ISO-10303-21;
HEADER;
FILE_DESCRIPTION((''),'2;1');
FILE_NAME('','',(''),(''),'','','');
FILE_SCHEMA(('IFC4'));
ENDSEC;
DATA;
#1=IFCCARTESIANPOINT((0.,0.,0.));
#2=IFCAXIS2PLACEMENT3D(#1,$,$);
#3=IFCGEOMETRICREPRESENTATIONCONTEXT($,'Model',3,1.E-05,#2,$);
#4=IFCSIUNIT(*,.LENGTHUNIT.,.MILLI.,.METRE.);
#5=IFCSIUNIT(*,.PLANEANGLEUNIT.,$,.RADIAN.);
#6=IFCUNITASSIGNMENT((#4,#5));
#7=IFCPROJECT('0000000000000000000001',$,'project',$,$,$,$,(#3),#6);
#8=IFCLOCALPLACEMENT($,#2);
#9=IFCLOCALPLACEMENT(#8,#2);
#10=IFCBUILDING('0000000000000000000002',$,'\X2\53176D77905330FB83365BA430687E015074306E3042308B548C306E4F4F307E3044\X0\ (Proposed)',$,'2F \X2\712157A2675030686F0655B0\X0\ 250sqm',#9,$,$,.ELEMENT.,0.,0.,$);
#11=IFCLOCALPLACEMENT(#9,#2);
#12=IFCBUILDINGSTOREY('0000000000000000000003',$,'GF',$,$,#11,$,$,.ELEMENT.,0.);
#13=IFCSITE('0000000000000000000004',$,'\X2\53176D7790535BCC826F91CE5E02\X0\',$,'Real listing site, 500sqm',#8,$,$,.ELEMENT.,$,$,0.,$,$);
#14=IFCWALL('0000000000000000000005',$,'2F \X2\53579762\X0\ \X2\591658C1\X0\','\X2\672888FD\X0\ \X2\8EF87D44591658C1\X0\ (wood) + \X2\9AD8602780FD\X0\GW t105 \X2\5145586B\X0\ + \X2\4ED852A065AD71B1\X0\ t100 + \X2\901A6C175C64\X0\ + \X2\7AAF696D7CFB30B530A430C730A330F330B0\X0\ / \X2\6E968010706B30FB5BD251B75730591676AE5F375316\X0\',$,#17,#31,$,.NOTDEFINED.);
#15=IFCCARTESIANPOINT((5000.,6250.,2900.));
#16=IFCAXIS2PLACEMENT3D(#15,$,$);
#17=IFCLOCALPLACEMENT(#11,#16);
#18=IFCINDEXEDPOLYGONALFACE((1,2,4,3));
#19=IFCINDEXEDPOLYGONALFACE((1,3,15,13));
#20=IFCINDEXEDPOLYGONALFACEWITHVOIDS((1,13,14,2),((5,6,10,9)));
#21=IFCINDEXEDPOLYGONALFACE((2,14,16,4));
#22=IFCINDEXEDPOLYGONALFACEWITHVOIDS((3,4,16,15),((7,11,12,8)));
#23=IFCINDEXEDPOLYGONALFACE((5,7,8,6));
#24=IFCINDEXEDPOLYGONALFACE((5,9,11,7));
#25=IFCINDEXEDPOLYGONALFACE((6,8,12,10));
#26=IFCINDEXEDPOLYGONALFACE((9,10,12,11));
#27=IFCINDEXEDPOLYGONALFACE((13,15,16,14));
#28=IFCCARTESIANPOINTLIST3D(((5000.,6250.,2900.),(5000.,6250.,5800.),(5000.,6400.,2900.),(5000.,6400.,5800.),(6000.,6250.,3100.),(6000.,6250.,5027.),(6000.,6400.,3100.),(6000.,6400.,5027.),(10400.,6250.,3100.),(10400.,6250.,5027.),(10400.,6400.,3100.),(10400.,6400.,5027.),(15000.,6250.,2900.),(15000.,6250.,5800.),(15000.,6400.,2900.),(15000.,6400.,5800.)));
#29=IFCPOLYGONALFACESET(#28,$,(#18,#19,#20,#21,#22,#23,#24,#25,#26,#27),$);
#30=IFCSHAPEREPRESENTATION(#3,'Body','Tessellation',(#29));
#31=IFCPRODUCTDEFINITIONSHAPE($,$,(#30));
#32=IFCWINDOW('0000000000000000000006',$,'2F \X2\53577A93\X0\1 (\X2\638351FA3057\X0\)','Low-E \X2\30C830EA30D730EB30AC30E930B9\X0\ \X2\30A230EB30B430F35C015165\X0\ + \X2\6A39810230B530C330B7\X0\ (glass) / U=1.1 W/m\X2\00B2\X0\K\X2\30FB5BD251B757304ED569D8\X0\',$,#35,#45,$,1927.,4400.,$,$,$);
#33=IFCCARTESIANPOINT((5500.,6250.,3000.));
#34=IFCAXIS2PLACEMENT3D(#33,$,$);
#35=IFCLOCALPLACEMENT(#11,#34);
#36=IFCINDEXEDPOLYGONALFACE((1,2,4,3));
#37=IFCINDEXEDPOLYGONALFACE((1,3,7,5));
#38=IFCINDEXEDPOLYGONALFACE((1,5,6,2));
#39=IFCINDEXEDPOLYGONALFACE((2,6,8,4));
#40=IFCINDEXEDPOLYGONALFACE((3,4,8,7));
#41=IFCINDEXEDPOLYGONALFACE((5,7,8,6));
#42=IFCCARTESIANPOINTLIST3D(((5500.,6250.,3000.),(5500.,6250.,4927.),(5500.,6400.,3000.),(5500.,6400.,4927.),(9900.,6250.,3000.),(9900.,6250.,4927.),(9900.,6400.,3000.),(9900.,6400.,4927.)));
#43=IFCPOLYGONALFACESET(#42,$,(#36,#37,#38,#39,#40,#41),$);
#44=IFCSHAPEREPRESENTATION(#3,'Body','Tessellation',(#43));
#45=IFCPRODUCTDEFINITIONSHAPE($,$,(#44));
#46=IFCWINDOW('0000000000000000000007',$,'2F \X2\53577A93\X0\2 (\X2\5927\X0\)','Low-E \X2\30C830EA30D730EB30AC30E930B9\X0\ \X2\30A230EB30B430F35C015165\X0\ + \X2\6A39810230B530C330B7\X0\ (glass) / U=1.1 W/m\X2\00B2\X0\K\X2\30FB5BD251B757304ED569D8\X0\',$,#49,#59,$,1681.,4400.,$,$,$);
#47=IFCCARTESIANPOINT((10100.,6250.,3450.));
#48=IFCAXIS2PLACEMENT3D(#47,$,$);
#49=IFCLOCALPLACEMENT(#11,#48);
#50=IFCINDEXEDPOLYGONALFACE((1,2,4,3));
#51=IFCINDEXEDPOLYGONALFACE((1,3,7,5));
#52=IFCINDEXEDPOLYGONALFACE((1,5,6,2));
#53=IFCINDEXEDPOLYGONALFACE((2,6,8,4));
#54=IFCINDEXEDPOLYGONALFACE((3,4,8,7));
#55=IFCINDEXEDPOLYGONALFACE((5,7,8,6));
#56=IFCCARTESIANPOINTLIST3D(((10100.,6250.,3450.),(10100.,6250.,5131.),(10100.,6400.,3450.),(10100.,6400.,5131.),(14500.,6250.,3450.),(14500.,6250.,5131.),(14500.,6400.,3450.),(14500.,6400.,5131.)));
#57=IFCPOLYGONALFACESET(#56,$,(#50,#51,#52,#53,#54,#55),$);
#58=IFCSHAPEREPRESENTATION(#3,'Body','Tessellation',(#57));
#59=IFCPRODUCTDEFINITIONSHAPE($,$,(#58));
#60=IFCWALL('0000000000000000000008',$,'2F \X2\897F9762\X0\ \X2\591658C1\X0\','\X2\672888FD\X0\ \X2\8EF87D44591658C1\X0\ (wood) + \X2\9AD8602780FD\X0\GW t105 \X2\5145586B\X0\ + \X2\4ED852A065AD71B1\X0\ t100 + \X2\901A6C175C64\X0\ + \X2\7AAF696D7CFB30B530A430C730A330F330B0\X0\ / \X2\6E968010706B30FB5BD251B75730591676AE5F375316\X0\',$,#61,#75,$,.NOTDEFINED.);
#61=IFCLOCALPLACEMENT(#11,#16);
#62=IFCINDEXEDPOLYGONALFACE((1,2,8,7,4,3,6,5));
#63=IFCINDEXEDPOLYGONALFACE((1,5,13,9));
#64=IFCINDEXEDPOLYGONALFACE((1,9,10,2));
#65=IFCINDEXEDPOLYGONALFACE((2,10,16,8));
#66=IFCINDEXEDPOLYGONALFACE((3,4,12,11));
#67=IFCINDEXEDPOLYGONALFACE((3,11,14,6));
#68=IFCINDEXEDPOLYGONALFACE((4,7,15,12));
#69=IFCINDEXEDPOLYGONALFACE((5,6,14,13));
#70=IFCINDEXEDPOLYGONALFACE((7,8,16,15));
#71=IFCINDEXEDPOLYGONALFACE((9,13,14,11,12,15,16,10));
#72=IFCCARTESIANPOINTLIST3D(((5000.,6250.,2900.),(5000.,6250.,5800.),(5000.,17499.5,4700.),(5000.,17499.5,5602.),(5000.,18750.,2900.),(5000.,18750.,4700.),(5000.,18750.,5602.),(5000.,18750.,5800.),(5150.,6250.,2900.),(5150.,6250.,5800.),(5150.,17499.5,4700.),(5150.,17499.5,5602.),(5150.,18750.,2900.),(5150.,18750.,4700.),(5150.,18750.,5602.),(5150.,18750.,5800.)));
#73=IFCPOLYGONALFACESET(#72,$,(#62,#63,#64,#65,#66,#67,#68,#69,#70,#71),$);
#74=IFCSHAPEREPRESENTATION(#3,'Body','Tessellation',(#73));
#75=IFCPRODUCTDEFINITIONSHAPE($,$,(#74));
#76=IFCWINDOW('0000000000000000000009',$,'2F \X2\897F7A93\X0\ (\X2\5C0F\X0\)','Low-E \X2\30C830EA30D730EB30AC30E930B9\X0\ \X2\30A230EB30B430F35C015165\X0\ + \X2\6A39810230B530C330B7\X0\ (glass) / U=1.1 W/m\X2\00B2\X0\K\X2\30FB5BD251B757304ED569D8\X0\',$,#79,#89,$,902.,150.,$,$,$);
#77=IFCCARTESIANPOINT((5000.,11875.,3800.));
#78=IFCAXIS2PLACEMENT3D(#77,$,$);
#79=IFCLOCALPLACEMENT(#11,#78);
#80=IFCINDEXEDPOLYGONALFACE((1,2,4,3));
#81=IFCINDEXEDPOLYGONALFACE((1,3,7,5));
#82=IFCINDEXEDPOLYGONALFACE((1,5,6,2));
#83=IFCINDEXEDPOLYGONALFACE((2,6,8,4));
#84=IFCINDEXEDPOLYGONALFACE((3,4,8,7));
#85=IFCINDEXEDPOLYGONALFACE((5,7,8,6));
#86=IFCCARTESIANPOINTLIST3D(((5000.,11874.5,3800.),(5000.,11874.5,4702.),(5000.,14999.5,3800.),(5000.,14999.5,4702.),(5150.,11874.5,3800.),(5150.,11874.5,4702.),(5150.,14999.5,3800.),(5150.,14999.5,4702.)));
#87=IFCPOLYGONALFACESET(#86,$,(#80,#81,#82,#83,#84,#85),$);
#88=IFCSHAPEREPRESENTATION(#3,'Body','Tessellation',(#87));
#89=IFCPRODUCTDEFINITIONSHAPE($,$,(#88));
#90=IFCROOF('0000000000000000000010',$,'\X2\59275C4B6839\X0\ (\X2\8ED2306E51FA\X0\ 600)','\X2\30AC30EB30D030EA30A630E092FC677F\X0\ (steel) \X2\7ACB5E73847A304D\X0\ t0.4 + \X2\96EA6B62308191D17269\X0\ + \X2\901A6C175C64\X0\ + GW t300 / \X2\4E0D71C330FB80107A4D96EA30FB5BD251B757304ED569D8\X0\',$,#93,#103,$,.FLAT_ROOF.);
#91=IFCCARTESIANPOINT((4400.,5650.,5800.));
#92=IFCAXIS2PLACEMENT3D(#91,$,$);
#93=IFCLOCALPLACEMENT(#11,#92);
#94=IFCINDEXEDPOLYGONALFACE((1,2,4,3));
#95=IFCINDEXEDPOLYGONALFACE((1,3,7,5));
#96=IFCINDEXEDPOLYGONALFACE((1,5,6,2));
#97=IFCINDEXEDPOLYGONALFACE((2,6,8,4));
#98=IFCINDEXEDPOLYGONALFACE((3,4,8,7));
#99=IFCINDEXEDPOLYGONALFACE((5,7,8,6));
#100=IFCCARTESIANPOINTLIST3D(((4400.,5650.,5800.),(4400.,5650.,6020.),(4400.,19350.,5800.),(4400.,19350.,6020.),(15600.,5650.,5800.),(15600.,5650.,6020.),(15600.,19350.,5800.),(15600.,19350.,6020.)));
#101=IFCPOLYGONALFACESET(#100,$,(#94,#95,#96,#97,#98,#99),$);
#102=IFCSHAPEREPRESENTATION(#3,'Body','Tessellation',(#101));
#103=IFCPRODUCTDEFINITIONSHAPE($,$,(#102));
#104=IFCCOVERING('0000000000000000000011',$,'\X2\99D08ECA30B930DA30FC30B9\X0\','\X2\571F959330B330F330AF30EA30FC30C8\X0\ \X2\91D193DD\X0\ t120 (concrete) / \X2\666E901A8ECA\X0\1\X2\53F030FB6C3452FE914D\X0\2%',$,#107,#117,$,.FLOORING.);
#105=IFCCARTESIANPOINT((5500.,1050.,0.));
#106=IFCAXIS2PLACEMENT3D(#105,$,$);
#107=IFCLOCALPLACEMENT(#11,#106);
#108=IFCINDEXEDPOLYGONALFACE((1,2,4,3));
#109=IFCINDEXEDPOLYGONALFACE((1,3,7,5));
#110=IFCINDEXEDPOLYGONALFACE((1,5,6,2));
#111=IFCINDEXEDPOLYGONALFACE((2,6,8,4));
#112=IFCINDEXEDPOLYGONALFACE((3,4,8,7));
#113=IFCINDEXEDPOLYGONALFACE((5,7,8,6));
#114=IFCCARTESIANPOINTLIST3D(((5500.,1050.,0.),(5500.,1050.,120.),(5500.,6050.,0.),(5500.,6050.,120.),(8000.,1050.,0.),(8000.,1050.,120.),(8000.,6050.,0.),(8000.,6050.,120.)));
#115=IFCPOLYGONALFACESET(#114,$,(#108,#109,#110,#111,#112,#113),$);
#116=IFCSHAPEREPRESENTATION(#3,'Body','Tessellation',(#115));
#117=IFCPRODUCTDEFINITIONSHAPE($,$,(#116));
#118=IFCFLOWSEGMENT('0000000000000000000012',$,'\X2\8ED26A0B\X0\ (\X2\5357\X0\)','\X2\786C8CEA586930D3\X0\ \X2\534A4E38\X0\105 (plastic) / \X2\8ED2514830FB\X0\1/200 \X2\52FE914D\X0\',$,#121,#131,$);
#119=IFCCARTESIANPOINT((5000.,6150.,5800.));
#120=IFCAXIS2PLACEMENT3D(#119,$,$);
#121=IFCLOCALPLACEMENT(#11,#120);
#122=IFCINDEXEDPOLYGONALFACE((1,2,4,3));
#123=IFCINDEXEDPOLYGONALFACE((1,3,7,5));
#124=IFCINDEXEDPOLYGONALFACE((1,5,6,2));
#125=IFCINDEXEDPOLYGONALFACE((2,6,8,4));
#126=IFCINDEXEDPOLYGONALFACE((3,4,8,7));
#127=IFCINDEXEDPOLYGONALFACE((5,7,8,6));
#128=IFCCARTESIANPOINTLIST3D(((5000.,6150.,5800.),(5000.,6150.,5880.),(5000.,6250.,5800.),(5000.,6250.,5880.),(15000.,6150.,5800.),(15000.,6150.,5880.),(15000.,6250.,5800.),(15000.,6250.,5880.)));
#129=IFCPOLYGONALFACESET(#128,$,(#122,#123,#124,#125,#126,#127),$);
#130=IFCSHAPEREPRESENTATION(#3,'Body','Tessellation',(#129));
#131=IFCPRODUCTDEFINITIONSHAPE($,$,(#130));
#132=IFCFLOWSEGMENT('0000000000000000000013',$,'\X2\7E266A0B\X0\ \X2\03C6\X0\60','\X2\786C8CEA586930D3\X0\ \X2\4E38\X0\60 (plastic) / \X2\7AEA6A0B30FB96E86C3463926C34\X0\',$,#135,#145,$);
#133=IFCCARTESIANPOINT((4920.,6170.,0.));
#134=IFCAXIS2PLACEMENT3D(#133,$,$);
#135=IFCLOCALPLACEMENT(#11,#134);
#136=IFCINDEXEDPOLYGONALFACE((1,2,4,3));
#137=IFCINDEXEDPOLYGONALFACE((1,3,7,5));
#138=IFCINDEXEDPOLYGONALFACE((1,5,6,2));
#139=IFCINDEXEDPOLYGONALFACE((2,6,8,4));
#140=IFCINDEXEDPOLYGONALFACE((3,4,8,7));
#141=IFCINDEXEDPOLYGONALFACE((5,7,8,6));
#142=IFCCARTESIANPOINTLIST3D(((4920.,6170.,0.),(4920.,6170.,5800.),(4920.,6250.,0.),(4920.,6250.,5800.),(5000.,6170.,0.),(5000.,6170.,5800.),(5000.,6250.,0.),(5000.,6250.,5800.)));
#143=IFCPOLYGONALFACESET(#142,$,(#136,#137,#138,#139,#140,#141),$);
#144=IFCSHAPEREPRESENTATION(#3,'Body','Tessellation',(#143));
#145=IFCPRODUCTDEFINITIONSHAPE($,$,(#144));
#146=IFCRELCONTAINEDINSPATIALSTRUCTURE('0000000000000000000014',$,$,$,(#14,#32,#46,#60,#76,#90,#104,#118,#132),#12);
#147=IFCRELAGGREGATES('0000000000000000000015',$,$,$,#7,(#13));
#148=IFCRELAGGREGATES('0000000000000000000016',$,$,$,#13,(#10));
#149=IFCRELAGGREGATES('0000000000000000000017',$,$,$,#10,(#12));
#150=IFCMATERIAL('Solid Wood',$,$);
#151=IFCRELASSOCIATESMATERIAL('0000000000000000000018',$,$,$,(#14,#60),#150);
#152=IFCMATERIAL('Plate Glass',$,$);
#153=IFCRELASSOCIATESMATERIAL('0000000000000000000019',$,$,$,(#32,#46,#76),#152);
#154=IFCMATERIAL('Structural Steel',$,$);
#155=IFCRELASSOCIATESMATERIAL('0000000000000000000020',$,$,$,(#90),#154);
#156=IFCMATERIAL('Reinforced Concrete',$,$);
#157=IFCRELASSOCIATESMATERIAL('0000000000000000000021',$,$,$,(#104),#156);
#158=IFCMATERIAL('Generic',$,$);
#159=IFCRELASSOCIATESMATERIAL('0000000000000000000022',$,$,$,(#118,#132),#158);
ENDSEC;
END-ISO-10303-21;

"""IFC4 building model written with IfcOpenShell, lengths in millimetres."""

from ifc_helpers import new_model, si_unit, frame, frame_2d, origin, place, context, project, spatial, rectangle, extrude, material, element, fill, save


model = new_model("IFC4")

# Units and contexts
model_context = context("Model", 3, precision=1e-05, world=origin())
ifc_project = project(units=[si_unit("LENGTHUNIT", "METRE", prefix="MILLI"), si_unit("PLANEANGLEUNIT", "RADIAN")], contexts=[model_context])

# Site, building, storey
site_placement = place(None, origin())
site = spatial("IfcSite", under=ifc_project, at=site_placement, Name="北海道富良野市", ObjectType="Real listing site, 500sqm", CompositionType="ELEMENT", RefElevation=0.0)
building_placement = place(site_placement, origin())
building = spatial("IfcBuilding", under=site, at=building_placement, Name="北海道・茶室と縁側のある和の住まい (Proposed)", ObjectType="2F 無垢材と漆喰 250sqm", CompositionType="ELEMENT", ElevationOfRefHeight=0.0, ElevationOfTerrain=0.0)
storey_placement = place(building_placement, origin())
storey = spatial("IfcBuildingStorey", under=building, at=storey_placement, Name="GF", CompositionType="ELEMENT", Elevation=0.0)

# Shared definitions
ifc_material_1 = material(Name="Solid Wood")

# Shared definitions
ifc_material_2 = material(Name="Reinforced Concrete")

# Shared definitions
ifc_material_3 = material(Name="Plate Glass")

# Wall, openings, windows
wall_1_placement = place(storey_placement, frame((5000.0, 6250.0, 2900.0)))
wall_1 = element("IfcWall", 1, at=wall_1_placement, inside=storey, material=ifc_material_1, Name="2F 南面 外壁", Description="木製 軸組外壁 (wood) + 高性能GW t105 充填 + 付加断熱 t100 + 通気層 + 窯業系サイディング / 準耐火・寒冷地外皮強化", PredefinedType="NOTDEFINED", context=model_context, shape_type="SweptSolid", body=[
    extrude(rectangle(XDim=10000.0, YDim=150.0, at=frame_2d((5000.0, 75.0))), frame((5000.0, 6250.0, 2900.0)), (0.0, 0.0, 1.0), 2900.0),
])
opening_1_placement = place(storey_placement, frame((5500.0, 6250.0, 3000.0)))
opening_1 = element("IfcOpeningElement", 2, at=opening_1_placement, cuts=wall_1, PredefinedType="NOTDEFINED", context=model_context, shape_type="SweptSolid", body=[
    extrude(rectangle(XDim=4400.0, YDim=150.0, at=frame_2d((2200.0, 75.0))), frame((5500.0, 6250.0, 3000.0)), (0.0, 0.0, 1.0), 1927.0),
])
opening_2_placement = place(storey_placement, frame((10100.0, 6250.0, 3450.0)))
opening_2 = element("IfcOpeningElement", 3, at=opening_2_placement, cuts=wall_1, PredefinedType="NOTDEFINED", context=model_context, shape_type="SweptSolid", body=[
    extrude(rectangle(XDim=4400.0, YDim=150.0, at=frame_2d((2200.0, 75.0))), frame((10100.0, 6250.0, 3450.0)), (0.0, 0.0, 1.0), 1681.0),
])
window_1_placement = place(storey_placement, frame((5500.0, 6250.0, 3000.0)))
window_1 = element("IfcWindow", 4, at=window_1_placement, inside=storey, material=ifc_material_3, Name="2F 南窓1 (掃出し)", Description="Low-E トリプルガラス アルゴン封入 + 樹脂サッシ (glass) / U=1.1 W/m²K・寒冷地仕様", OverallHeight=1927.0, OverallWidth=4400.0, context=model_context, shape_type="SweptSolid", body=[
    extrude(rectangle(XDim=4400.0, YDim=150.0, at=frame_2d((2200.0, 75.0))), frame((5500.0, 6250.0, 3000.0)), (0.0, 0.0, 1.0), 1927.0),
])
fill(opening_1, window_1)
window_2_placement = place(storey_placement, frame((10100.0, 6250.0, 3450.0)))
window_2 = element("IfcWindow", 5, at=window_2_placement, inside=storey, material=ifc_material_3, Name="2F 南窓2 (大)", Description="Low-E トリプルガラス アルゴン封入 + 樹脂サッシ (glass) / U=1.1 W/m²K・寒冷地仕様", OverallHeight=1681.0, OverallWidth=4400.0, context=model_context, shape_type="SweptSolid", body=[
    extrude(rectangle(XDim=4400.0, YDim=150.0, at=frame_2d((2200.0, 75.0))), frame((10100.0, 6250.0, 3450.0)), (0.0, 0.0, 1.0), 1681.0),
])
fill(opening_2, window_2)

# Wall, opening, window
wall_2_placement = place(storey_placement, frame((5000.0, 6250.0, 2900.0)))
wall_2 = element("IfcWall", 6, at=wall_2_placement, inside=storey, material=ifc_material_1, Name="2F 西面 外壁", Description="木製 軸組外壁 (wood) + 高性能GW t105 充填 + 付加断熱 t100 + 通気層 + 窯業系サイディング / 準耐火・寒冷地外皮強化", PredefinedType="NOTDEFINED", context=model_context, shape_type="SweptSolid", body=[
    extrude(rectangle(XDim=150.0, YDim=12500.0, at=frame_2d((75.0, 6250.0))), frame((5000.0, 6250.0, 2900.0)), (0.0, 0.0, 1.0), 2900.0),
])
opening_3_placement = place(storey_placement, frame((5000.0, 11875.0, 3800.0)))
opening_3 = element("IfcOpeningElement", 7, at=opening_3_placement, cuts=wall_2, PredefinedType="NOTDEFINED", context=model_context, shape_type="SweptSolid", body=[
    extrude(rectangle(XDim=150.0, YDim=3125.0, at=frame_2d((75.0, 1562.0))), frame((5000.0, 11875.0, 3800.0)), (0.0, 0.0, 1.0), 902.0),
])
window_3_placement = place(storey_placement, frame((5000.0, 11875.0, 3800.0)))
window_3 = element("IfcWindow", 8, at=window_3_placement, inside=storey, material=ifc_material_3, Name="2F 西窓 (小)", Description="Low-E トリプルガラス アルゴン封入 + 樹脂サッシ (glass) / U=1.1 W/m²K・寒冷地仕様", OverallHeight=902.0, OverallWidth=150.0, context=model_context, shape_type="SweptSolid", body=[
    extrude(rectangle(XDim=150.0, YDim=3125.0, at=frame_2d((75.0, 1562.0))), frame((5000.0, 11875.0, 3800.0)), (0.0, 0.0, 1.0), 902.0),
])
fill(opening_3, window_3)

# Roof
ifc_material_4 = material(Name="Structural Steel")
roof_placement = place(storey_placement, frame((4400.0, 5650.0, 5800.0)))
element("IfcRoof", 9, at=roof_placement, inside=storey, material=ifc_material_4, Name="大屋根 (軒の出 600)", Description="ガルバリウム鋼板 (steel) 立平葺き t0.4 + 雪止め金物 + 通気層 + GW t300 / 不燃・耐積雪・寒冷地仕様", PredefinedType="FLAT_ROOF", context=model_context, shape_type="SweptSolid", body=[
    extrude(rectangle(XDim=11200.0, YDim=13700.0, at=frame_2d((5600.0, 6850.0))), frame((4400.0, 5650.0, 5800.0)), (0.0, 0.0, 1.0), 220.0),
])

# Covering
covering_placement = place(storey_placement, frame((5500.0, 1050.0, 0.0)))
element("IfcCovering", 10, at=covering_placement, inside=storey, material=ifc_material_2, Name="駐車スペース", Description="土間コンクリート 金鏝 t120 (concrete) / 普通車1台・水勾配2%", PredefinedType="FLOORING", context=model_context, shape_type="SweptSolid", body=[
    extrude(rectangle(XDim=2500.0, YDim=5000.0, at=frame_2d((1250.0, 2500.0))), frame((5500.0, 1050.0, 0.0)), (0.0, 0.0, 1.0), 120.0),
])

# Flow segments
ifc_material_5 = material(Name="Generic")
flow_segment_1_placement = place(storey_placement, frame((5000.0, 6150.0, 5800.0)))
element("IfcFlowSegment", 11, at=flow_segment_1_placement, inside=storey, material=ifc_material_5, Name="軒樋 (南)", Description="硬質塩ビ 半丸105 (plastic) / 軒先・1/200 勾配", context=model_context, shape_type="SweptSolid", body=[
    extrude(rectangle(XDim=10000.0, YDim=100.0, at=frame_2d((5000.0, 50.0))), frame((5000.0, 6150.0, 5800.0)), (0.0, 0.0, 1.0), 80.0),
])
flow_segment_2_placement = place(storey_placement, frame((4920.0, 6170.0, 0.0)))
element("IfcFlowSegment", 12, at=flow_segment_2_placement, inside=storey, material=ifc_material_5, Name="縦樋 φ60", Description="硬質塩ビ 丸60 (plastic) / 竪樋・雨水排水", context=model_context, shape_type="SweptSolid", body=[
    extrude(rectangle(XDim=80.0, YDim=80.0, at=frame_2d((40.0, 40.0))), frame((4920.0, 6170.0, 0.0)), (0.0, 0.0, 1.0), 5800.0),
])

save(model, "model.ifc")
